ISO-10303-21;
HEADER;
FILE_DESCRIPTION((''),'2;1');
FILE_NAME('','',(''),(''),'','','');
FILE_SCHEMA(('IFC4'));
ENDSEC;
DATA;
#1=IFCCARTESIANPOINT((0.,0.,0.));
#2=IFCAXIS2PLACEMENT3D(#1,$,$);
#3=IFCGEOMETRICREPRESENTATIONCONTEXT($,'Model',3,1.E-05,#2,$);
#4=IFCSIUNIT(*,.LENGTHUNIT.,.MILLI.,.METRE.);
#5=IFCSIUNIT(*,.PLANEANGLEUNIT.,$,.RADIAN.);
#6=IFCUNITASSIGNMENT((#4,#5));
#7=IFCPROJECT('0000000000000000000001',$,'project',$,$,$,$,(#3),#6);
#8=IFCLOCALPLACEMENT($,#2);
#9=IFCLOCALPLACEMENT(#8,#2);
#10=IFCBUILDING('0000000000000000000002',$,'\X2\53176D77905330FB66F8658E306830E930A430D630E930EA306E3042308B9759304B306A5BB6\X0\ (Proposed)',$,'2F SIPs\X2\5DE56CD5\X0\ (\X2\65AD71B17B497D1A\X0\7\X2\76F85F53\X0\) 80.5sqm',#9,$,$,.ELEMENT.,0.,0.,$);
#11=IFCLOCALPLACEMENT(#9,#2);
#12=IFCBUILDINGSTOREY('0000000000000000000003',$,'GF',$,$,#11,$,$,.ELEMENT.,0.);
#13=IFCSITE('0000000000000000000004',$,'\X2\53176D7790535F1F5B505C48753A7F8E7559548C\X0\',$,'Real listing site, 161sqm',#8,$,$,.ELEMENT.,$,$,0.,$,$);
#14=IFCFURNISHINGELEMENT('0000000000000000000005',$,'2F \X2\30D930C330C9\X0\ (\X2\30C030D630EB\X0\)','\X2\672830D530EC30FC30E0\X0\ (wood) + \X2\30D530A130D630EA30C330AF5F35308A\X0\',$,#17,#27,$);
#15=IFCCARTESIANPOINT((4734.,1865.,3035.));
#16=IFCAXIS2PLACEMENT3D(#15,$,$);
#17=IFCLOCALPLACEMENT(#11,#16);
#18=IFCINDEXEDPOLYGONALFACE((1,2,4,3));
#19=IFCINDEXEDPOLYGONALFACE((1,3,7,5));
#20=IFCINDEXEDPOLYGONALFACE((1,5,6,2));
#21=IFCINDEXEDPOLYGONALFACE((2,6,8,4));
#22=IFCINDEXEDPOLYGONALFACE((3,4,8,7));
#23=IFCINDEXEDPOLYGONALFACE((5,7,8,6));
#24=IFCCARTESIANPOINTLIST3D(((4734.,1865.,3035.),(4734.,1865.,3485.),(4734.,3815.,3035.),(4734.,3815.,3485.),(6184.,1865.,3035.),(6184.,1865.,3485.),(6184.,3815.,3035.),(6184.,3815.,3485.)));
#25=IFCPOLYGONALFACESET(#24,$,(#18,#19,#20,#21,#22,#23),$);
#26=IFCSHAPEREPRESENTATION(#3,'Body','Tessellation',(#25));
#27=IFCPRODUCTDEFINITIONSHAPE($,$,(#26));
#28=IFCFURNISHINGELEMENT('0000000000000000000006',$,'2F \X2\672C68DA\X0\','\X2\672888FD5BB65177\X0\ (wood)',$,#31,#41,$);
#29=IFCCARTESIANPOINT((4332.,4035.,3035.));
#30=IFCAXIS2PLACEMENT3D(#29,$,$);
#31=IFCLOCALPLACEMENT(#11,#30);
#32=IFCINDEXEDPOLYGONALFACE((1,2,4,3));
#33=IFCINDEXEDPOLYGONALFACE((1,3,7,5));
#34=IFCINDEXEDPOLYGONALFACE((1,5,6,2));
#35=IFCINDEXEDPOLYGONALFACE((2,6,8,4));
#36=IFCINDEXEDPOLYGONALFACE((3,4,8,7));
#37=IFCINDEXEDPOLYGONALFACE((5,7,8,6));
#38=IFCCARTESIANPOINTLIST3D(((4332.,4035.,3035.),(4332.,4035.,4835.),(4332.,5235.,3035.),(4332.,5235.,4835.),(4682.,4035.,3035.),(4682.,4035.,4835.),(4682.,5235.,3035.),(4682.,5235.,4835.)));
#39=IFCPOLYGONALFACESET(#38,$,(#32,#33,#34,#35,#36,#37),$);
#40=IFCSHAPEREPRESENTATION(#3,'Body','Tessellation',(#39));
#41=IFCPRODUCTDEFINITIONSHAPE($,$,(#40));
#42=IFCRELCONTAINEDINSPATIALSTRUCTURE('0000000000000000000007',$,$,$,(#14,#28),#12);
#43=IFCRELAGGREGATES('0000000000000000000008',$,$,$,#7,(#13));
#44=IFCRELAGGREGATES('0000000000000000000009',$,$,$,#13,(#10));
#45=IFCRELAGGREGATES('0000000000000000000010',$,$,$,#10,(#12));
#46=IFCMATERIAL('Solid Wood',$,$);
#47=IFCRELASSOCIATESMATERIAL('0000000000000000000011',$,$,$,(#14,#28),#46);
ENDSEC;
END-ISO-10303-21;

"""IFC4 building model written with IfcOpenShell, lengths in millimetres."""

from ifc_helpers import new_model, si_unit, frame, frame_2d, origin, place, context, project, spatial, rectangle, extrude, material, element, save


model = new_model("IFC4")

# Units and contexts
model_context = context("Model", 3, precision=1e-05, world=origin())
ifc_project = project(units=[si_unit("LENGTHUNIT", "METRE", prefix="MILLI"), si_unit("PLANEANGLEUNIT", "RADIAN")], contexts=[model_context])

# Site, building, storey
site_placement = place(None, origin())
site = spatial("IfcSite", under=ifc_project, at=site_placement, Name="北海道弟子屈町美留和", ObjectType="Real listing site, 161sqm", CompositionType="ELEMENT", RefElevation=0.0)
building_placement = place(site_placement, origin())
building = spatial("IfcBuilding", under=site, at=building_placement, Name="北海道・書斎とライブラリのある静かな家 (Proposed)", ObjectType="2F SIPs工法 (断熱等級7相当) 80.5sqm", CompositionType="ELEMENT", ElevationOfRefHeight=0.0, ElevationOfTerrain=0.0)
storey_placement = place(building_placement, origin())
storey = spatial("IfcBuildingStorey", under=building, at=storey_placement, Name="GF", CompositionType="ELEMENT", Elevation=0.0)

# Shared definitions
ifc_material_1 = material(Name="Solid Wood")

# Furnishing elements
furnishing_1_placement = place(storey_placement, frame((4734.0, 1865.0, 3035.0)))
element("IfcFurnishingElement", 1, at=furnishing_1_placement, inside=storey, material=ifc_material_1, Name="2F ベッド (ダブル)", Description="木フレーム (wood) + ファブリック張り", context=model_context, shape_type="SweptSolid", body=[
    extrude(rectangle(XDim=1450.0, YDim=1950.0, at=frame_2d((725.0, 975.0))), frame((4734.0, 1865.0, 3035.0)), (0.0, 0.0, 1.0), 450.0),
])
furnishing_2_placement = place(storey_placement, frame((4332.0, 4035.0, 3035.0)))
element("IfcFurnishingElement", 2, at=furnishing_2_placement, inside=storey, material=ifc_material_1, Name="2F 本棚", Description="木製家具 (wood)", context=model_context, shape_type="SweptSolid", body=[
    extrude(rectangle(XDim=350.0, YDim=1200.0, at=frame_2d((175.0, 600.0))), frame((4332.0, 4035.0, 3035.0)), (0.0, 0.0, 1.0), 1800.0),
])

save(model, "model.ifc")
